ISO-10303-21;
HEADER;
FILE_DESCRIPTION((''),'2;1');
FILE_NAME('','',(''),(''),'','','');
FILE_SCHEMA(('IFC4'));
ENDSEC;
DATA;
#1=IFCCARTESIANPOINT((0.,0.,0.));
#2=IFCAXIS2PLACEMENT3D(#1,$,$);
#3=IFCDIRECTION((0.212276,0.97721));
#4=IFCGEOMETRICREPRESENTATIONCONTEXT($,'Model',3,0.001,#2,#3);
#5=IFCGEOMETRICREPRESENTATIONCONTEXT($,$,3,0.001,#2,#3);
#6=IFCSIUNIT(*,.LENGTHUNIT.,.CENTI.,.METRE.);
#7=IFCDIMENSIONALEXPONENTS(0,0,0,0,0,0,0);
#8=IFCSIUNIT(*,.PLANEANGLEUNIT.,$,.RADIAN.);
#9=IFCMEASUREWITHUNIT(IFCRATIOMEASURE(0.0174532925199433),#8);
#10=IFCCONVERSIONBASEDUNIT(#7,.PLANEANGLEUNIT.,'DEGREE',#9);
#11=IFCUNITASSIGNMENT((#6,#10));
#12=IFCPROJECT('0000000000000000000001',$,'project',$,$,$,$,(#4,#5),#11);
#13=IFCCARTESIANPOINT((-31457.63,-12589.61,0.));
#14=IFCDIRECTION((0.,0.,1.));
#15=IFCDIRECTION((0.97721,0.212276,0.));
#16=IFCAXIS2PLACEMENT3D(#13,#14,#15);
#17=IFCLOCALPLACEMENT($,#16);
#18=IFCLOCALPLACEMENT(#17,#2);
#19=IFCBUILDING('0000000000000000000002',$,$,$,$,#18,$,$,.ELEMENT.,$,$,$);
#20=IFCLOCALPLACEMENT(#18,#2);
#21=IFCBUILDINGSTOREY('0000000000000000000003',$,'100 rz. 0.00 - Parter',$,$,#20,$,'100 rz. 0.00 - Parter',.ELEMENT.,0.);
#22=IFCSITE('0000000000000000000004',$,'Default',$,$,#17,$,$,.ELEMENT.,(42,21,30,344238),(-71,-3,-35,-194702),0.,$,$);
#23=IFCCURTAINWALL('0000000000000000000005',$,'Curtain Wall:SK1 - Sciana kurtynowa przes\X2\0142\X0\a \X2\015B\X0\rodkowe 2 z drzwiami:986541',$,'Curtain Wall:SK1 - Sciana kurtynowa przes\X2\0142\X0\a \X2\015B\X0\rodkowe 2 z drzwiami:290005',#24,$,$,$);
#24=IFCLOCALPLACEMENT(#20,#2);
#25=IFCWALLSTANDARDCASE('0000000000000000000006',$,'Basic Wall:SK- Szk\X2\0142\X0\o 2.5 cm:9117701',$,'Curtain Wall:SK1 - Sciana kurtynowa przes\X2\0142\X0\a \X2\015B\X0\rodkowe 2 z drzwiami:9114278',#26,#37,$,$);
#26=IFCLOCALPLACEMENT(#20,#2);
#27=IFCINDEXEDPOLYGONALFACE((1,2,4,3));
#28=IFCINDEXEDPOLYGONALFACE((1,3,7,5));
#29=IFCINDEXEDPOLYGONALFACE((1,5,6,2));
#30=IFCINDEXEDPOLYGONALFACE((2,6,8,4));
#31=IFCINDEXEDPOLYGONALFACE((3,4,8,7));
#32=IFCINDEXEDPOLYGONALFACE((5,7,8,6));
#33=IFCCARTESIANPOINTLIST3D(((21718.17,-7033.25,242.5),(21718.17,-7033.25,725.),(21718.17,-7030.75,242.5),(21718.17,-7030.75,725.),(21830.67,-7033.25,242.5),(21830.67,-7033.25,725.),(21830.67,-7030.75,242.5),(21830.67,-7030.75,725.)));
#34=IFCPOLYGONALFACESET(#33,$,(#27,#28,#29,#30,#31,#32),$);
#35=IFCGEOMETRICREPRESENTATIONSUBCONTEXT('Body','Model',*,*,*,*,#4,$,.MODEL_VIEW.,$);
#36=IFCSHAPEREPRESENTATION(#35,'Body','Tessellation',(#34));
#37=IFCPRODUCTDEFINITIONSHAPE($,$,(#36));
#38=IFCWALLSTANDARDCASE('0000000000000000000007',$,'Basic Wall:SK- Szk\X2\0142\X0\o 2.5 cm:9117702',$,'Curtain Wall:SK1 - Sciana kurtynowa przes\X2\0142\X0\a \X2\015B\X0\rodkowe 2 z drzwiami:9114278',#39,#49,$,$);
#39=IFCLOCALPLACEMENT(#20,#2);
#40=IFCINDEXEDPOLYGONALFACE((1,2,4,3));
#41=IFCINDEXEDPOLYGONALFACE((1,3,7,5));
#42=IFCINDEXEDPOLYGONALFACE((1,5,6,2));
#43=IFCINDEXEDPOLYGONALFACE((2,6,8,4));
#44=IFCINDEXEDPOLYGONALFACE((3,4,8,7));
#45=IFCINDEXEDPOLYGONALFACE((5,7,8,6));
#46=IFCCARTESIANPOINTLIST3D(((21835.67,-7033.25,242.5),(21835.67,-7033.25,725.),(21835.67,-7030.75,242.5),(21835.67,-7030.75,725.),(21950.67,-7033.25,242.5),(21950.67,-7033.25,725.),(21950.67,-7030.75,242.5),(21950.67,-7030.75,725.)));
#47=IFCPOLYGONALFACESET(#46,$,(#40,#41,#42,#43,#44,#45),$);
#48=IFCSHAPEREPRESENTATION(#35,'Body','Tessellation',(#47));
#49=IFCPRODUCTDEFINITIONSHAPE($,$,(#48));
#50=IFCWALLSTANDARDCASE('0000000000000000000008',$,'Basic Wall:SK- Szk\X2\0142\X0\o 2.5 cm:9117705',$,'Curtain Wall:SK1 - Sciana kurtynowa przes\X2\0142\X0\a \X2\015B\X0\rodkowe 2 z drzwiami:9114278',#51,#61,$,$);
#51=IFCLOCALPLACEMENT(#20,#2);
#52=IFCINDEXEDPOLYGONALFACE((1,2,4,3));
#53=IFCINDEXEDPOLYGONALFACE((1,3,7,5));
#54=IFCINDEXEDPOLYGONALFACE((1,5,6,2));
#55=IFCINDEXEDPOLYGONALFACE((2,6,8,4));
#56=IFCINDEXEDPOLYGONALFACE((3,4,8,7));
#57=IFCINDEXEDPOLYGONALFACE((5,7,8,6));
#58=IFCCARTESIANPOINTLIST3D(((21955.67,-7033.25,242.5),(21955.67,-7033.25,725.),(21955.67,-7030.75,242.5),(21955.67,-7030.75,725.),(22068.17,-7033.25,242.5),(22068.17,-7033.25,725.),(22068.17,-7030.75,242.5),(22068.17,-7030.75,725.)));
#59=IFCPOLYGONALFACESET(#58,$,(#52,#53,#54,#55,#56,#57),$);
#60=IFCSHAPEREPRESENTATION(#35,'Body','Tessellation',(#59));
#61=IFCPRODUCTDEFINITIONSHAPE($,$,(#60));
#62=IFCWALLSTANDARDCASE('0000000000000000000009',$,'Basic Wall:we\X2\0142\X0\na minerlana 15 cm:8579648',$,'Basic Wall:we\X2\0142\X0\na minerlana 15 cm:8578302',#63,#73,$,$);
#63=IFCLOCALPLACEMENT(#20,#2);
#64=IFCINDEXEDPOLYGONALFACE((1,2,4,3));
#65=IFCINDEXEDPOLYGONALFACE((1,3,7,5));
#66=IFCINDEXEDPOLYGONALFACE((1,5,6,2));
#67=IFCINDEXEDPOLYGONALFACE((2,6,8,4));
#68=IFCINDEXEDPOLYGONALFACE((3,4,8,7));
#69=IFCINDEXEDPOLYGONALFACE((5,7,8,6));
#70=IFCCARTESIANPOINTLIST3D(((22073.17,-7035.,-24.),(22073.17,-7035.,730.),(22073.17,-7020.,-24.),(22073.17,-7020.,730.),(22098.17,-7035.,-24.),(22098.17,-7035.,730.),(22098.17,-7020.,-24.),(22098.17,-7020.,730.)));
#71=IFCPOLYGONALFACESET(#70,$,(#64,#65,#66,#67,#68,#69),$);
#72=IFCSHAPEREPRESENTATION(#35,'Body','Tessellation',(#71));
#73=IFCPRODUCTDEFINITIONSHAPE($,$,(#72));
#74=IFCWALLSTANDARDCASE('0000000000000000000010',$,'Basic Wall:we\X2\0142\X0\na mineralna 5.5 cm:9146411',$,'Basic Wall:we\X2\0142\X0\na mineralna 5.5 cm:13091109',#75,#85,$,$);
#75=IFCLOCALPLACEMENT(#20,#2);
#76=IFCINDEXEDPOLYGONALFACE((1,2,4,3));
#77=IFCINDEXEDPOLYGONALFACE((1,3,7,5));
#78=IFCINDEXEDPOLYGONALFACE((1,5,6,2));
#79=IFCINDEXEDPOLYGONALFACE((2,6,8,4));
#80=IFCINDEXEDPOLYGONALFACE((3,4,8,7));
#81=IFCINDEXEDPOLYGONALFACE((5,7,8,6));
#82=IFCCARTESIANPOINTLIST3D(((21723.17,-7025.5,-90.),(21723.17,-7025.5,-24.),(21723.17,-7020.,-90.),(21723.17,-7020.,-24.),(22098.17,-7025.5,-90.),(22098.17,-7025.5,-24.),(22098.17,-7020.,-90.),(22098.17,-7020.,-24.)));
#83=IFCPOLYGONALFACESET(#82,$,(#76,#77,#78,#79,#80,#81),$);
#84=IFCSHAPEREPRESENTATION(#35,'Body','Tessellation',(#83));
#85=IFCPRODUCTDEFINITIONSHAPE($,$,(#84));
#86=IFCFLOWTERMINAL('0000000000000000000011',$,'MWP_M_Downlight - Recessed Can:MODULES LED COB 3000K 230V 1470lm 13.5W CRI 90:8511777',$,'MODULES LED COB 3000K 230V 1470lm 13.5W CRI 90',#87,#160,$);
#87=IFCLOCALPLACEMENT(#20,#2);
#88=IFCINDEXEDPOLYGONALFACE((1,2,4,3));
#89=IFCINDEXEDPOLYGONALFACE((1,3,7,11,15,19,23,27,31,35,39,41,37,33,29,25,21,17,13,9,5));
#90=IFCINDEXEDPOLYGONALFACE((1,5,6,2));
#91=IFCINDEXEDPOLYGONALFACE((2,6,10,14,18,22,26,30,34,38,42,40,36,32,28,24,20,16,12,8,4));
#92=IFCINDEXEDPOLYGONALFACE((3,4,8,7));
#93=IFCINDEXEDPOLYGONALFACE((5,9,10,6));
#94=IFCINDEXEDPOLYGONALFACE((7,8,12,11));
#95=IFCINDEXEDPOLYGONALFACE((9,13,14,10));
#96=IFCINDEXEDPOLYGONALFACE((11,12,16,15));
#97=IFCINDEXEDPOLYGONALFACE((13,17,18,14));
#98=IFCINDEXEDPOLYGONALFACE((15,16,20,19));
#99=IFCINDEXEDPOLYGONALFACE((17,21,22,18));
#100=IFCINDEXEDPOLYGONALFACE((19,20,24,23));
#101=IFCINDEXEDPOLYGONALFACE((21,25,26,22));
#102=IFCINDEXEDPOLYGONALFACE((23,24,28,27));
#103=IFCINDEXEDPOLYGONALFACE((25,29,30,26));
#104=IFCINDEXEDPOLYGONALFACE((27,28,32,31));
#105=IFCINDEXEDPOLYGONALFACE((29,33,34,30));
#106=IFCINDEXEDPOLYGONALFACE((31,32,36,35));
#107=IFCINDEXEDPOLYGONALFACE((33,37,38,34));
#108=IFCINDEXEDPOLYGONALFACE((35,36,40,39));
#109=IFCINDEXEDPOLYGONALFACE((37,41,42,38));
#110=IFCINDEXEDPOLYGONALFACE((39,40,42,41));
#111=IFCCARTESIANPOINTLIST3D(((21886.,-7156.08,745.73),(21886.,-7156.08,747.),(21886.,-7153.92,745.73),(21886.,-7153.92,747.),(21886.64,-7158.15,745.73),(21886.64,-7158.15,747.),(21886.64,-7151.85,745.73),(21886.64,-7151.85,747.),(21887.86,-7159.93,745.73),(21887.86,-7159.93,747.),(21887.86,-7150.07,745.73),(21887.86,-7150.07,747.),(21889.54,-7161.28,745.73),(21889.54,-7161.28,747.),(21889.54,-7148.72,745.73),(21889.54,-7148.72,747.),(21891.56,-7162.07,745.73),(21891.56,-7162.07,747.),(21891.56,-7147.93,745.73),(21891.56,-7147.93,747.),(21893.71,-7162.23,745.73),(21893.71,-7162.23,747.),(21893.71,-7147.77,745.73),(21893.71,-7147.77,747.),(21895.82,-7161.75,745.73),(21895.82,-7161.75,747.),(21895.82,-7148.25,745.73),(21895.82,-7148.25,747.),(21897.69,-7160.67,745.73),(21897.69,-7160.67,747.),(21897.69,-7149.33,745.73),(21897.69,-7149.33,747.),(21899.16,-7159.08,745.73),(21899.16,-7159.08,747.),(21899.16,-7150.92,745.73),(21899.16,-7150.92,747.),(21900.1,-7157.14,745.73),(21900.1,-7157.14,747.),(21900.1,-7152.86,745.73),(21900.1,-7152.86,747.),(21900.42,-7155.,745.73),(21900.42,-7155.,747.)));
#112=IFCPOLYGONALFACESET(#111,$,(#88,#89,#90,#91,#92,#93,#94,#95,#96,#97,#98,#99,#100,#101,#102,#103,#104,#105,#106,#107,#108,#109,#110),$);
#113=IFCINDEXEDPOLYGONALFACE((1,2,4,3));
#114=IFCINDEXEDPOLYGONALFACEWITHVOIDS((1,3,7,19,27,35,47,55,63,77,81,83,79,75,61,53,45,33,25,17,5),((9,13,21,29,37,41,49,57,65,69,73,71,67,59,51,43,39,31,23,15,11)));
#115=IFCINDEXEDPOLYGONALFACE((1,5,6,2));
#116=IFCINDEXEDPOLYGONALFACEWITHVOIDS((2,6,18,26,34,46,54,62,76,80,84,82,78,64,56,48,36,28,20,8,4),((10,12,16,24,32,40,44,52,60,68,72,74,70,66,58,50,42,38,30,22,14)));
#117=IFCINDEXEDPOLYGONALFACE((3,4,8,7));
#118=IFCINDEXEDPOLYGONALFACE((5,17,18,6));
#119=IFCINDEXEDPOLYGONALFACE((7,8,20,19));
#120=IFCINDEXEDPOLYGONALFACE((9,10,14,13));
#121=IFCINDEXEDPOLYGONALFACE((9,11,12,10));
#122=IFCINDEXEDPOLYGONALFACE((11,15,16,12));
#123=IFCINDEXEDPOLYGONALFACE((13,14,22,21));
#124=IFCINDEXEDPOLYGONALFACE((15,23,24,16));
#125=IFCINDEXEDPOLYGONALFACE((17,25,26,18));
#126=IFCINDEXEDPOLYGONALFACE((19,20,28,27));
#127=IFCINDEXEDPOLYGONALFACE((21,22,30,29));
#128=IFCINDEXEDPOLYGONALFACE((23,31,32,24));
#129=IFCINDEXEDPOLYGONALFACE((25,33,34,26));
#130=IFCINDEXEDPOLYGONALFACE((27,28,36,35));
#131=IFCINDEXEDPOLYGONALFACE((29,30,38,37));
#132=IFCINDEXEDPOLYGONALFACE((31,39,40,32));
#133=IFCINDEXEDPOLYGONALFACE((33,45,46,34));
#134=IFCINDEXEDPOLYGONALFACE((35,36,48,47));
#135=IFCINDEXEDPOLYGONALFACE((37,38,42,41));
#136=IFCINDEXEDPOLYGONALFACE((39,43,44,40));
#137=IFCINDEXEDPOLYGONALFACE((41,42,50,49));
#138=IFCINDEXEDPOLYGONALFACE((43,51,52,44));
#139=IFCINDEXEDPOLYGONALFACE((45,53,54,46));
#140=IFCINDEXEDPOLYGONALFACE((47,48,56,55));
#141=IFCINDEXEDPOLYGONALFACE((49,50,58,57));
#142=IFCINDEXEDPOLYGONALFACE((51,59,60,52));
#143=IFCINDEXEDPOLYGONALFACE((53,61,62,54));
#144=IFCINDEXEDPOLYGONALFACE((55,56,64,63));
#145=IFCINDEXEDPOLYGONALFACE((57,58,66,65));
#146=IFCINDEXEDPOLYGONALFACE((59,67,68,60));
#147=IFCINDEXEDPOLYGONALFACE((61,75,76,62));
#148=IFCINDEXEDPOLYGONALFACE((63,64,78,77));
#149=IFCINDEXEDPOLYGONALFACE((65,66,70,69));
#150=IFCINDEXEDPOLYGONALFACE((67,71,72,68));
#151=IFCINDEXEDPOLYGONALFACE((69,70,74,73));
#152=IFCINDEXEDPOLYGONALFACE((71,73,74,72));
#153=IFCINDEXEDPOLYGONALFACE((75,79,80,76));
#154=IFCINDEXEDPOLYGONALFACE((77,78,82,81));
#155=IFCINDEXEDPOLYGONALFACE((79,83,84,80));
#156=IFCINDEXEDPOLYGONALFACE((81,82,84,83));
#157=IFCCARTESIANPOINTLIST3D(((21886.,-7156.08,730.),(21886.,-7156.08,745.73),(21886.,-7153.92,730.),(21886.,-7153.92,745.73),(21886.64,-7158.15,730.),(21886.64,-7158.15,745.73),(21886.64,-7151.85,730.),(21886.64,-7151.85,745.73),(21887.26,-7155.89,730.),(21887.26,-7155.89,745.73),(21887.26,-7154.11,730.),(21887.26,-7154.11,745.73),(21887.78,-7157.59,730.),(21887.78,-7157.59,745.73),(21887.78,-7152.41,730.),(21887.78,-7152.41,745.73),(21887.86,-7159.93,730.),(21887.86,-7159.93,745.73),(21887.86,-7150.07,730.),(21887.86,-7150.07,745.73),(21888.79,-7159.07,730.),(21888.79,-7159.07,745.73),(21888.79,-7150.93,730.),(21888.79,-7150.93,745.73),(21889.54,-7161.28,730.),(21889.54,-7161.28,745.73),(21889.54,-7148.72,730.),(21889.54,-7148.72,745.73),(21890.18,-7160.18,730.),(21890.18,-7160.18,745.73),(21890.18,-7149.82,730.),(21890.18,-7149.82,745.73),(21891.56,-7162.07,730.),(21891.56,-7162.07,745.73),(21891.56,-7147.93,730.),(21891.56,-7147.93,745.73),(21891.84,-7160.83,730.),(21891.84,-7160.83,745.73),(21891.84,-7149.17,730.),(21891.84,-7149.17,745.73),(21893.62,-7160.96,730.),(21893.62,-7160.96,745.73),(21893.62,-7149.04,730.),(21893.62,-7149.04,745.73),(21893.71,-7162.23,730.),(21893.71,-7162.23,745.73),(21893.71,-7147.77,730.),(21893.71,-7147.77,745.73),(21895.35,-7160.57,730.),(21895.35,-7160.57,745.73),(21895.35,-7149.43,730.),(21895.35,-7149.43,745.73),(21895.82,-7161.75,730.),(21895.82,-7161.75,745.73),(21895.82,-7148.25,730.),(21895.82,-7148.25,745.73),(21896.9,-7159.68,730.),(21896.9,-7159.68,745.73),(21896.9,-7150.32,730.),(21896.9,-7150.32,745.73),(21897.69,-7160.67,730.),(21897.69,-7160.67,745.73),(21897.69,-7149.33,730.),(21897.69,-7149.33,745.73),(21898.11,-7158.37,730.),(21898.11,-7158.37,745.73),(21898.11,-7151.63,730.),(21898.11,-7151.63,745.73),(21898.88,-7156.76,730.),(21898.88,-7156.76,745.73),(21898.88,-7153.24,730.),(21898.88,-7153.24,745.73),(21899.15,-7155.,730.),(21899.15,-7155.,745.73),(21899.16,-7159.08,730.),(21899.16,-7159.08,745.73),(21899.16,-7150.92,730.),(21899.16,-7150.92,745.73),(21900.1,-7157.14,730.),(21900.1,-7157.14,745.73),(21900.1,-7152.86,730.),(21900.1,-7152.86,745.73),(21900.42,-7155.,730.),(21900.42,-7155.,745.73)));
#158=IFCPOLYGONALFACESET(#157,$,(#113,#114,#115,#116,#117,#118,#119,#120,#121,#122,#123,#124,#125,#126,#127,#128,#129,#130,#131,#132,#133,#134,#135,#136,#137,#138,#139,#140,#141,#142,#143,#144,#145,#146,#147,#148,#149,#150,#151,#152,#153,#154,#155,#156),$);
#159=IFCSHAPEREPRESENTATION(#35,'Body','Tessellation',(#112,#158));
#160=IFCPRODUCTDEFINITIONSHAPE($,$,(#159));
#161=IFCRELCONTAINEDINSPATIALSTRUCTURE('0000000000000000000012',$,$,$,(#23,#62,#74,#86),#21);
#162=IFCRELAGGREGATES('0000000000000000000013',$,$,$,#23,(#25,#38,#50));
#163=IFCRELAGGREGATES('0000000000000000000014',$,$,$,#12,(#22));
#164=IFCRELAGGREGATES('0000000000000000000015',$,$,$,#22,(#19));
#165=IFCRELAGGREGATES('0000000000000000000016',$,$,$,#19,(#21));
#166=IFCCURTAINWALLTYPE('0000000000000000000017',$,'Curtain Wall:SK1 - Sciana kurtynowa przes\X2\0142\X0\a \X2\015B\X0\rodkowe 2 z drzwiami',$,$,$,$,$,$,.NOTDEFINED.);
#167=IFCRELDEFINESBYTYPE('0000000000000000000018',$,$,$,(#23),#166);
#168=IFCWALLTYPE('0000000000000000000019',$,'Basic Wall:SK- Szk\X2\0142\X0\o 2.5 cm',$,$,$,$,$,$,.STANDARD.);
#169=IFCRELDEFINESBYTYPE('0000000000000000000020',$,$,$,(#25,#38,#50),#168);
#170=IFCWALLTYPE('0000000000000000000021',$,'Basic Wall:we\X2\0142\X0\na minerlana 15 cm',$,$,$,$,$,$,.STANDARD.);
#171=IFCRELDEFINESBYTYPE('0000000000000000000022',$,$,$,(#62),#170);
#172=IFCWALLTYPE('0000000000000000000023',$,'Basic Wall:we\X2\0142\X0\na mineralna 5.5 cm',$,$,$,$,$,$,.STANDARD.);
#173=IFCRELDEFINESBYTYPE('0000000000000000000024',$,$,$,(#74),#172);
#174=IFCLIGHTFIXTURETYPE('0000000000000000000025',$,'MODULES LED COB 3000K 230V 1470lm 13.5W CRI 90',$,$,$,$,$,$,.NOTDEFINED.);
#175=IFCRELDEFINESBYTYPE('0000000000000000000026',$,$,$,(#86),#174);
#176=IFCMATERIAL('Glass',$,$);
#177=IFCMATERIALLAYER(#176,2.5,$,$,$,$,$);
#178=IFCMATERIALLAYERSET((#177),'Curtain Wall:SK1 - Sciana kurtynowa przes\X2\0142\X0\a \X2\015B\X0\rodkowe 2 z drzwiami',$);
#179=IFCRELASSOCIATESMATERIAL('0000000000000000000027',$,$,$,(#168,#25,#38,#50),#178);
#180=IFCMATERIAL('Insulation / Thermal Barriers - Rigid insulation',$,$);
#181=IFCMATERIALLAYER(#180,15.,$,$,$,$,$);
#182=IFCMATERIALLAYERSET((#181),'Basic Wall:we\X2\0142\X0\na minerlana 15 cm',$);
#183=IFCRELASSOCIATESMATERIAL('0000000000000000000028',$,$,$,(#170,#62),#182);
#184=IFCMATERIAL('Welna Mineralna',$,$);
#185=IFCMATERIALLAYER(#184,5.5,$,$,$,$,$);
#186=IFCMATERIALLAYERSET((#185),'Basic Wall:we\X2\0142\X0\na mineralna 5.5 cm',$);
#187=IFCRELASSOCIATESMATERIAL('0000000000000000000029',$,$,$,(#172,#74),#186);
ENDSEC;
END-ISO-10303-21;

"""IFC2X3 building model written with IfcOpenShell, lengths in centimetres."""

from ifc_helpers import new_model, entity, si_unit, converted_unit, direction, frame, frame_2d, origin, place, context, subcontext, project, spatial, rectangle, circle, hollow_circle, extrude, source, transform, mapped, material, layer, layer_set, layer_usage, type_object, type_shapes, element, aggregate, save


model = new_model("IFC2X3")

# Units and contexts
model_context = context("Model", 3, precision=0.001, world=origin(), true_north=direction((0.212276, 0.97721)))
context_of_model = context(None, 3, precision=0.001, world=origin(), true_north=direction((0.212276, 0.97721)))
body_context = subcontext(model_context, "Body", "Model", "MODEL_VIEW")
ifc_project = project(units=[si_unit("LENGTHUNIT", "METRE", prefix="CENTI"), converted_unit("PLANEANGLEUNIT", "DEGREE", entity("IfcRatioMeasure", 0.0174532925199433), si_unit("PLANEANGLEUNIT", "RADIAN"), dimensions=[0, 0, 0, 0, 0, 0, 0])], contexts=[model_context, context_of_model])

# Site, building, storey
site_placement = place(None, frame((-31457.63, -12589.61, 0.0), z_axis=(0.0, 0.0, 1.0), x_axis=(0.97721, 0.212276, 0.0)))
site = spatial("IfcSite", under=ifc_project, at=site_placement, Name="Default", CompositionType="ELEMENT", RefLatitude=(42, 21, 30, 344238), RefLongitude=(-71, -3, -35, -194702), RefElevation=0.0)
building_placement = place(site_placement, origin())
building = spatial("IfcBuilding", under=site, at=building_placement, CompositionType="ELEMENT")
storey_placement = place(building_placement, origin())
storey = spatial("IfcBuildingStorey", under=building, at=storey_placement, Name="100 rz. 0.00 - Parter", LongName="100 rz. 0.00 - Parter", CompositionType="ELEMENT", Elevation=0.0)

# Curtain wall
curtain_wall_type = type_object("IfcCurtainWallType", Name="Curtain Wall:SK1 - Sciana kurtynowa przesła środkowe 2 z drzwiami", PredefinedType="NOTDEFINED")
curtain_wall_placement = place(storey_placement, origin())
curtain_wall = element("IfcCurtainWall", 1, at=curtain_wall_placement, inside=storey, type_object=curtain_wall_type, Name="Curtain Wall:SK1 - Sciana kurtynowa przesła środkowe 2 z drzwiami:986541", ObjectType="Curtain Wall:SK1 - Sciana kurtynowa przesła środkowe 2 z drzwiami:290005")

# Walls
ifc_material_1 = material(Name="Glass")
ifc_layer_1 = layer(ifc_material_1, 2.5)
ifc_layer_set_1 = layer_set([ifc_layer_1], Name="Curtain Wall:SK1 - Sciana kurtynowa przesła środkowe 2 z drzwiami")
wall_type_1 = type_object("IfcWallType", Name="Basic Wall:SK- Szkło 2.5 cm", PredefinedType="STANDARD", material=ifc_layer_set_1)
ifc_layer_usage_1 = layer_usage(ifc_layer_set_1, "AXIS2", "POSITIVE", -1.25)
wall_1_placement = place(storey_placement, frame((21718.17, -7032.0, 242.5)))
wall_1 = element("IfcWallStandardCase", 2, at=wall_1_placement, type_object=wall_type_1, material=ifc_layer_usage_1, Name="Basic Wall:SK- Szkło 2.5 cm:9117701", ObjectType="Curtain Wall:SK1 - Sciana kurtynowa przesła środkowe 2 z drzwiami:9114278", context=body_context, shape_type="SweptSolid", body=[
    extrude(rectangle(XDim=112.5, YDim=2.5, at=frame_2d((56.25, 0.0), x_axis=(-1.0, 0.0))), origin(), (0.0, 0.0, 1.0), 482.5),
])
ifc_layer_usage_2 = layer_usage(ifc_layer_set_1, "AXIS2", "POSITIVE", -1.25)
wall_2_placement = place(storey_placement, frame((21835.67, -7032.0, 242.5)))
wall_2 = element("IfcWallStandardCase", 3, at=wall_2_placement, type_object=wall_type_1, material=ifc_layer_usage_2, Name="Basic Wall:SK- Szkło 2.5 cm:9117702", ObjectType="Curtain Wall:SK1 - Sciana kurtynowa przesła środkowe 2 z drzwiami:9114278", context=body_context, shape_type="SweptSolid", body=[
    extrude(rectangle(XDim=115.0, YDim=2.5, at=frame_2d((57.5, 0.0), x_axis=(-1.0, 0.0))), origin(), (0.0, 0.0, 1.0), 482.5),
])
ifc_layer_usage_3 = layer_usage(ifc_layer_set_1, "AXIS2", "POSITIVE", -1.25)
wall_3_placement = place(storey_placement, frame((21955.67, -7032.0, 242.5)))
wall_3 = element("IfcWallStandardCase", 4, at=wall_3_placement, type_object=wall_type_1, material=ifc_layer_usage_3, Name="Basic Wall:SK- Szkło 2.5 cm:9117705", ObjectType="Curtain Wall:SK1 - Sciana kurtynowa przesła środkowe 2 z drzwiami:9114278", context=body_context, shape_type="SweptSolid", body=[
    extrude(rectangle(XDim=112.5, YDim=2.5, at=frame_2d((56.25, 0.0), x_axis=(-1.0, 0.0))), origin(), (0.0, 0.0, 1.0), 482.5),
])
aggregate(curtain_wall, [wall_1, wall_2, wall_3])
ifc_material_2 = material(Name="Insulation / Thermal Barriers - Rigid insulation")
ifc_layer_2 = layer(ifc_material_2, 15.0)
ifc_layer_set_2 = layer_set([ifc_layer_2], Name="Basic Wall:wełna minerlana 15 cm")
ifc_layer_usage_4 = layer_usage(ifc_layer_set_2, "AXIS2", "NEGATIVE", 7.5)
wall_type_2 = type_object("IfcWallType", Name="Basic Wall:wełna minerlana 15 cm", PredefinedType="STANDARD", material=ifc_layer_set_2)
wall_4_placement = place(storey_placement, frame((22098.17, -7027.5, -24.0), z_axis=(0.0, 0.0, 1.0), x_axis=(-1.0, 0.0, 0.0)))
element("IfcWallStandardCase", 5, at=wall_4_placement, inside=storey, type_object=wall_type_2, material=ifc_layer_usage_4, Name="Basic Wall:wełna minerlana 15 cm:8579648", ObjectType="Basic Wall:wełna minerlana 15 cm:8578302", context=body_context, shape_type="SweptSolid", body=[
    extrude(rectangle(XDim=25.0, YDim=15.0, at=frame_2d((12.5, 0.0), x_axis=(-1.0, 0.0))), origin(), (0.0, 0.0, 1.0), 754.0),
])

# Wall
ifc_material_3 = material(Name="Welna Mineralna")
ifc_layer_3 = layer(ifc_material_3, 5.5)
ifc_layer_set_3 = layer_set([ifc_layer_3], Name="Basic Wall:wełna mineralna 5.5 cm")
ifc_layer_usage_5 = layer_usage(ifc_layer_set_3, "AXIS2", "NEGATIVE", 2.75)
wall_type_3 = type_object("IfcWallType", Name="Basic Wall:wełna mineralna 5.5 cm", PredefinedType="STANDARD", material=ifc_layer_set_3)
wall_5_placement = place(storey_placement, frame((22098.17, -7022.75, -90.0), z_axis=(0.0, 0.0, 1.0), x_axis=(-1.0, 0.0, 0.0)))
element("IfcWallStandardCase", 6, at=wall_5_placement, inside=storey, type_object=wall_type_3, material=ifc_layer_usage_5, Name="Basic Wall:wełna mineralna 5.5 cm:9146411", ObjectType="Basic Wall:wełna mineralna 5.5 cm:13091109", context=body_context, shape_type="SweptSolid", body=[
    extrude(rectangle(XDim=375.0, YDim=5.5, at=frame_2d((187.5, 0.0), x_axis=(-1.0, 0.0))), origin(), (0.0, 0.0, 1.0), 66.0),
])

# Flow terminal
light_fixture_type_1 = type_object("IfcLightFixtureType", Name="MODULES LED COB 3000K 230V 1470lm 13.5W CRI 90", PredefinedType="NOTDEFINED")
shared_shape_1 = source(origin(), body_context, "Body", "SweptSolid", [
    extrude(circle(Radius=7.25, at=frame_2d((0.0, 0.0), x_axis=(1.0, 0.0))), frame((7.41, 7.41, 15.73)), (0.0, 0.0, 1.0), 1.27),
    extrude(hollow_circle(Radius=7.25, WallThickness=1.27, at=frame_2d((0.0, 0.0), x_axis=(1.0, 0.0))), frame((7.41, 7.41, 0.0)), (0.0, 0.0, 1.0), 15.73),
])
type_shapes(light_fixture_type_1, [shared_shape_1])
for number, where, name in (
    (7, (21885.76, -7162.41, 730.0), "MWP_M_Downlight - Recessed Can:MODULES LED COB 3000K 230V 1470lm 13.5W CRI 90:8511777"),
):
    element("IfcFlowTerminal", number, at=place(storey_placement, frame(where)), inside=storey, type_object=light_fixture_type_1, Name=name, ObjectType="MODULES LED COB 3000K 230V 1470lm 13.5W CRI 90", context=body_context, shape_type="MappedRepresentation", body=[
        mapped(shared_shape_1, transform((0.0, 0.0, 0.0), scale=1.0)),
    ])

save(model, "model.ifc")
